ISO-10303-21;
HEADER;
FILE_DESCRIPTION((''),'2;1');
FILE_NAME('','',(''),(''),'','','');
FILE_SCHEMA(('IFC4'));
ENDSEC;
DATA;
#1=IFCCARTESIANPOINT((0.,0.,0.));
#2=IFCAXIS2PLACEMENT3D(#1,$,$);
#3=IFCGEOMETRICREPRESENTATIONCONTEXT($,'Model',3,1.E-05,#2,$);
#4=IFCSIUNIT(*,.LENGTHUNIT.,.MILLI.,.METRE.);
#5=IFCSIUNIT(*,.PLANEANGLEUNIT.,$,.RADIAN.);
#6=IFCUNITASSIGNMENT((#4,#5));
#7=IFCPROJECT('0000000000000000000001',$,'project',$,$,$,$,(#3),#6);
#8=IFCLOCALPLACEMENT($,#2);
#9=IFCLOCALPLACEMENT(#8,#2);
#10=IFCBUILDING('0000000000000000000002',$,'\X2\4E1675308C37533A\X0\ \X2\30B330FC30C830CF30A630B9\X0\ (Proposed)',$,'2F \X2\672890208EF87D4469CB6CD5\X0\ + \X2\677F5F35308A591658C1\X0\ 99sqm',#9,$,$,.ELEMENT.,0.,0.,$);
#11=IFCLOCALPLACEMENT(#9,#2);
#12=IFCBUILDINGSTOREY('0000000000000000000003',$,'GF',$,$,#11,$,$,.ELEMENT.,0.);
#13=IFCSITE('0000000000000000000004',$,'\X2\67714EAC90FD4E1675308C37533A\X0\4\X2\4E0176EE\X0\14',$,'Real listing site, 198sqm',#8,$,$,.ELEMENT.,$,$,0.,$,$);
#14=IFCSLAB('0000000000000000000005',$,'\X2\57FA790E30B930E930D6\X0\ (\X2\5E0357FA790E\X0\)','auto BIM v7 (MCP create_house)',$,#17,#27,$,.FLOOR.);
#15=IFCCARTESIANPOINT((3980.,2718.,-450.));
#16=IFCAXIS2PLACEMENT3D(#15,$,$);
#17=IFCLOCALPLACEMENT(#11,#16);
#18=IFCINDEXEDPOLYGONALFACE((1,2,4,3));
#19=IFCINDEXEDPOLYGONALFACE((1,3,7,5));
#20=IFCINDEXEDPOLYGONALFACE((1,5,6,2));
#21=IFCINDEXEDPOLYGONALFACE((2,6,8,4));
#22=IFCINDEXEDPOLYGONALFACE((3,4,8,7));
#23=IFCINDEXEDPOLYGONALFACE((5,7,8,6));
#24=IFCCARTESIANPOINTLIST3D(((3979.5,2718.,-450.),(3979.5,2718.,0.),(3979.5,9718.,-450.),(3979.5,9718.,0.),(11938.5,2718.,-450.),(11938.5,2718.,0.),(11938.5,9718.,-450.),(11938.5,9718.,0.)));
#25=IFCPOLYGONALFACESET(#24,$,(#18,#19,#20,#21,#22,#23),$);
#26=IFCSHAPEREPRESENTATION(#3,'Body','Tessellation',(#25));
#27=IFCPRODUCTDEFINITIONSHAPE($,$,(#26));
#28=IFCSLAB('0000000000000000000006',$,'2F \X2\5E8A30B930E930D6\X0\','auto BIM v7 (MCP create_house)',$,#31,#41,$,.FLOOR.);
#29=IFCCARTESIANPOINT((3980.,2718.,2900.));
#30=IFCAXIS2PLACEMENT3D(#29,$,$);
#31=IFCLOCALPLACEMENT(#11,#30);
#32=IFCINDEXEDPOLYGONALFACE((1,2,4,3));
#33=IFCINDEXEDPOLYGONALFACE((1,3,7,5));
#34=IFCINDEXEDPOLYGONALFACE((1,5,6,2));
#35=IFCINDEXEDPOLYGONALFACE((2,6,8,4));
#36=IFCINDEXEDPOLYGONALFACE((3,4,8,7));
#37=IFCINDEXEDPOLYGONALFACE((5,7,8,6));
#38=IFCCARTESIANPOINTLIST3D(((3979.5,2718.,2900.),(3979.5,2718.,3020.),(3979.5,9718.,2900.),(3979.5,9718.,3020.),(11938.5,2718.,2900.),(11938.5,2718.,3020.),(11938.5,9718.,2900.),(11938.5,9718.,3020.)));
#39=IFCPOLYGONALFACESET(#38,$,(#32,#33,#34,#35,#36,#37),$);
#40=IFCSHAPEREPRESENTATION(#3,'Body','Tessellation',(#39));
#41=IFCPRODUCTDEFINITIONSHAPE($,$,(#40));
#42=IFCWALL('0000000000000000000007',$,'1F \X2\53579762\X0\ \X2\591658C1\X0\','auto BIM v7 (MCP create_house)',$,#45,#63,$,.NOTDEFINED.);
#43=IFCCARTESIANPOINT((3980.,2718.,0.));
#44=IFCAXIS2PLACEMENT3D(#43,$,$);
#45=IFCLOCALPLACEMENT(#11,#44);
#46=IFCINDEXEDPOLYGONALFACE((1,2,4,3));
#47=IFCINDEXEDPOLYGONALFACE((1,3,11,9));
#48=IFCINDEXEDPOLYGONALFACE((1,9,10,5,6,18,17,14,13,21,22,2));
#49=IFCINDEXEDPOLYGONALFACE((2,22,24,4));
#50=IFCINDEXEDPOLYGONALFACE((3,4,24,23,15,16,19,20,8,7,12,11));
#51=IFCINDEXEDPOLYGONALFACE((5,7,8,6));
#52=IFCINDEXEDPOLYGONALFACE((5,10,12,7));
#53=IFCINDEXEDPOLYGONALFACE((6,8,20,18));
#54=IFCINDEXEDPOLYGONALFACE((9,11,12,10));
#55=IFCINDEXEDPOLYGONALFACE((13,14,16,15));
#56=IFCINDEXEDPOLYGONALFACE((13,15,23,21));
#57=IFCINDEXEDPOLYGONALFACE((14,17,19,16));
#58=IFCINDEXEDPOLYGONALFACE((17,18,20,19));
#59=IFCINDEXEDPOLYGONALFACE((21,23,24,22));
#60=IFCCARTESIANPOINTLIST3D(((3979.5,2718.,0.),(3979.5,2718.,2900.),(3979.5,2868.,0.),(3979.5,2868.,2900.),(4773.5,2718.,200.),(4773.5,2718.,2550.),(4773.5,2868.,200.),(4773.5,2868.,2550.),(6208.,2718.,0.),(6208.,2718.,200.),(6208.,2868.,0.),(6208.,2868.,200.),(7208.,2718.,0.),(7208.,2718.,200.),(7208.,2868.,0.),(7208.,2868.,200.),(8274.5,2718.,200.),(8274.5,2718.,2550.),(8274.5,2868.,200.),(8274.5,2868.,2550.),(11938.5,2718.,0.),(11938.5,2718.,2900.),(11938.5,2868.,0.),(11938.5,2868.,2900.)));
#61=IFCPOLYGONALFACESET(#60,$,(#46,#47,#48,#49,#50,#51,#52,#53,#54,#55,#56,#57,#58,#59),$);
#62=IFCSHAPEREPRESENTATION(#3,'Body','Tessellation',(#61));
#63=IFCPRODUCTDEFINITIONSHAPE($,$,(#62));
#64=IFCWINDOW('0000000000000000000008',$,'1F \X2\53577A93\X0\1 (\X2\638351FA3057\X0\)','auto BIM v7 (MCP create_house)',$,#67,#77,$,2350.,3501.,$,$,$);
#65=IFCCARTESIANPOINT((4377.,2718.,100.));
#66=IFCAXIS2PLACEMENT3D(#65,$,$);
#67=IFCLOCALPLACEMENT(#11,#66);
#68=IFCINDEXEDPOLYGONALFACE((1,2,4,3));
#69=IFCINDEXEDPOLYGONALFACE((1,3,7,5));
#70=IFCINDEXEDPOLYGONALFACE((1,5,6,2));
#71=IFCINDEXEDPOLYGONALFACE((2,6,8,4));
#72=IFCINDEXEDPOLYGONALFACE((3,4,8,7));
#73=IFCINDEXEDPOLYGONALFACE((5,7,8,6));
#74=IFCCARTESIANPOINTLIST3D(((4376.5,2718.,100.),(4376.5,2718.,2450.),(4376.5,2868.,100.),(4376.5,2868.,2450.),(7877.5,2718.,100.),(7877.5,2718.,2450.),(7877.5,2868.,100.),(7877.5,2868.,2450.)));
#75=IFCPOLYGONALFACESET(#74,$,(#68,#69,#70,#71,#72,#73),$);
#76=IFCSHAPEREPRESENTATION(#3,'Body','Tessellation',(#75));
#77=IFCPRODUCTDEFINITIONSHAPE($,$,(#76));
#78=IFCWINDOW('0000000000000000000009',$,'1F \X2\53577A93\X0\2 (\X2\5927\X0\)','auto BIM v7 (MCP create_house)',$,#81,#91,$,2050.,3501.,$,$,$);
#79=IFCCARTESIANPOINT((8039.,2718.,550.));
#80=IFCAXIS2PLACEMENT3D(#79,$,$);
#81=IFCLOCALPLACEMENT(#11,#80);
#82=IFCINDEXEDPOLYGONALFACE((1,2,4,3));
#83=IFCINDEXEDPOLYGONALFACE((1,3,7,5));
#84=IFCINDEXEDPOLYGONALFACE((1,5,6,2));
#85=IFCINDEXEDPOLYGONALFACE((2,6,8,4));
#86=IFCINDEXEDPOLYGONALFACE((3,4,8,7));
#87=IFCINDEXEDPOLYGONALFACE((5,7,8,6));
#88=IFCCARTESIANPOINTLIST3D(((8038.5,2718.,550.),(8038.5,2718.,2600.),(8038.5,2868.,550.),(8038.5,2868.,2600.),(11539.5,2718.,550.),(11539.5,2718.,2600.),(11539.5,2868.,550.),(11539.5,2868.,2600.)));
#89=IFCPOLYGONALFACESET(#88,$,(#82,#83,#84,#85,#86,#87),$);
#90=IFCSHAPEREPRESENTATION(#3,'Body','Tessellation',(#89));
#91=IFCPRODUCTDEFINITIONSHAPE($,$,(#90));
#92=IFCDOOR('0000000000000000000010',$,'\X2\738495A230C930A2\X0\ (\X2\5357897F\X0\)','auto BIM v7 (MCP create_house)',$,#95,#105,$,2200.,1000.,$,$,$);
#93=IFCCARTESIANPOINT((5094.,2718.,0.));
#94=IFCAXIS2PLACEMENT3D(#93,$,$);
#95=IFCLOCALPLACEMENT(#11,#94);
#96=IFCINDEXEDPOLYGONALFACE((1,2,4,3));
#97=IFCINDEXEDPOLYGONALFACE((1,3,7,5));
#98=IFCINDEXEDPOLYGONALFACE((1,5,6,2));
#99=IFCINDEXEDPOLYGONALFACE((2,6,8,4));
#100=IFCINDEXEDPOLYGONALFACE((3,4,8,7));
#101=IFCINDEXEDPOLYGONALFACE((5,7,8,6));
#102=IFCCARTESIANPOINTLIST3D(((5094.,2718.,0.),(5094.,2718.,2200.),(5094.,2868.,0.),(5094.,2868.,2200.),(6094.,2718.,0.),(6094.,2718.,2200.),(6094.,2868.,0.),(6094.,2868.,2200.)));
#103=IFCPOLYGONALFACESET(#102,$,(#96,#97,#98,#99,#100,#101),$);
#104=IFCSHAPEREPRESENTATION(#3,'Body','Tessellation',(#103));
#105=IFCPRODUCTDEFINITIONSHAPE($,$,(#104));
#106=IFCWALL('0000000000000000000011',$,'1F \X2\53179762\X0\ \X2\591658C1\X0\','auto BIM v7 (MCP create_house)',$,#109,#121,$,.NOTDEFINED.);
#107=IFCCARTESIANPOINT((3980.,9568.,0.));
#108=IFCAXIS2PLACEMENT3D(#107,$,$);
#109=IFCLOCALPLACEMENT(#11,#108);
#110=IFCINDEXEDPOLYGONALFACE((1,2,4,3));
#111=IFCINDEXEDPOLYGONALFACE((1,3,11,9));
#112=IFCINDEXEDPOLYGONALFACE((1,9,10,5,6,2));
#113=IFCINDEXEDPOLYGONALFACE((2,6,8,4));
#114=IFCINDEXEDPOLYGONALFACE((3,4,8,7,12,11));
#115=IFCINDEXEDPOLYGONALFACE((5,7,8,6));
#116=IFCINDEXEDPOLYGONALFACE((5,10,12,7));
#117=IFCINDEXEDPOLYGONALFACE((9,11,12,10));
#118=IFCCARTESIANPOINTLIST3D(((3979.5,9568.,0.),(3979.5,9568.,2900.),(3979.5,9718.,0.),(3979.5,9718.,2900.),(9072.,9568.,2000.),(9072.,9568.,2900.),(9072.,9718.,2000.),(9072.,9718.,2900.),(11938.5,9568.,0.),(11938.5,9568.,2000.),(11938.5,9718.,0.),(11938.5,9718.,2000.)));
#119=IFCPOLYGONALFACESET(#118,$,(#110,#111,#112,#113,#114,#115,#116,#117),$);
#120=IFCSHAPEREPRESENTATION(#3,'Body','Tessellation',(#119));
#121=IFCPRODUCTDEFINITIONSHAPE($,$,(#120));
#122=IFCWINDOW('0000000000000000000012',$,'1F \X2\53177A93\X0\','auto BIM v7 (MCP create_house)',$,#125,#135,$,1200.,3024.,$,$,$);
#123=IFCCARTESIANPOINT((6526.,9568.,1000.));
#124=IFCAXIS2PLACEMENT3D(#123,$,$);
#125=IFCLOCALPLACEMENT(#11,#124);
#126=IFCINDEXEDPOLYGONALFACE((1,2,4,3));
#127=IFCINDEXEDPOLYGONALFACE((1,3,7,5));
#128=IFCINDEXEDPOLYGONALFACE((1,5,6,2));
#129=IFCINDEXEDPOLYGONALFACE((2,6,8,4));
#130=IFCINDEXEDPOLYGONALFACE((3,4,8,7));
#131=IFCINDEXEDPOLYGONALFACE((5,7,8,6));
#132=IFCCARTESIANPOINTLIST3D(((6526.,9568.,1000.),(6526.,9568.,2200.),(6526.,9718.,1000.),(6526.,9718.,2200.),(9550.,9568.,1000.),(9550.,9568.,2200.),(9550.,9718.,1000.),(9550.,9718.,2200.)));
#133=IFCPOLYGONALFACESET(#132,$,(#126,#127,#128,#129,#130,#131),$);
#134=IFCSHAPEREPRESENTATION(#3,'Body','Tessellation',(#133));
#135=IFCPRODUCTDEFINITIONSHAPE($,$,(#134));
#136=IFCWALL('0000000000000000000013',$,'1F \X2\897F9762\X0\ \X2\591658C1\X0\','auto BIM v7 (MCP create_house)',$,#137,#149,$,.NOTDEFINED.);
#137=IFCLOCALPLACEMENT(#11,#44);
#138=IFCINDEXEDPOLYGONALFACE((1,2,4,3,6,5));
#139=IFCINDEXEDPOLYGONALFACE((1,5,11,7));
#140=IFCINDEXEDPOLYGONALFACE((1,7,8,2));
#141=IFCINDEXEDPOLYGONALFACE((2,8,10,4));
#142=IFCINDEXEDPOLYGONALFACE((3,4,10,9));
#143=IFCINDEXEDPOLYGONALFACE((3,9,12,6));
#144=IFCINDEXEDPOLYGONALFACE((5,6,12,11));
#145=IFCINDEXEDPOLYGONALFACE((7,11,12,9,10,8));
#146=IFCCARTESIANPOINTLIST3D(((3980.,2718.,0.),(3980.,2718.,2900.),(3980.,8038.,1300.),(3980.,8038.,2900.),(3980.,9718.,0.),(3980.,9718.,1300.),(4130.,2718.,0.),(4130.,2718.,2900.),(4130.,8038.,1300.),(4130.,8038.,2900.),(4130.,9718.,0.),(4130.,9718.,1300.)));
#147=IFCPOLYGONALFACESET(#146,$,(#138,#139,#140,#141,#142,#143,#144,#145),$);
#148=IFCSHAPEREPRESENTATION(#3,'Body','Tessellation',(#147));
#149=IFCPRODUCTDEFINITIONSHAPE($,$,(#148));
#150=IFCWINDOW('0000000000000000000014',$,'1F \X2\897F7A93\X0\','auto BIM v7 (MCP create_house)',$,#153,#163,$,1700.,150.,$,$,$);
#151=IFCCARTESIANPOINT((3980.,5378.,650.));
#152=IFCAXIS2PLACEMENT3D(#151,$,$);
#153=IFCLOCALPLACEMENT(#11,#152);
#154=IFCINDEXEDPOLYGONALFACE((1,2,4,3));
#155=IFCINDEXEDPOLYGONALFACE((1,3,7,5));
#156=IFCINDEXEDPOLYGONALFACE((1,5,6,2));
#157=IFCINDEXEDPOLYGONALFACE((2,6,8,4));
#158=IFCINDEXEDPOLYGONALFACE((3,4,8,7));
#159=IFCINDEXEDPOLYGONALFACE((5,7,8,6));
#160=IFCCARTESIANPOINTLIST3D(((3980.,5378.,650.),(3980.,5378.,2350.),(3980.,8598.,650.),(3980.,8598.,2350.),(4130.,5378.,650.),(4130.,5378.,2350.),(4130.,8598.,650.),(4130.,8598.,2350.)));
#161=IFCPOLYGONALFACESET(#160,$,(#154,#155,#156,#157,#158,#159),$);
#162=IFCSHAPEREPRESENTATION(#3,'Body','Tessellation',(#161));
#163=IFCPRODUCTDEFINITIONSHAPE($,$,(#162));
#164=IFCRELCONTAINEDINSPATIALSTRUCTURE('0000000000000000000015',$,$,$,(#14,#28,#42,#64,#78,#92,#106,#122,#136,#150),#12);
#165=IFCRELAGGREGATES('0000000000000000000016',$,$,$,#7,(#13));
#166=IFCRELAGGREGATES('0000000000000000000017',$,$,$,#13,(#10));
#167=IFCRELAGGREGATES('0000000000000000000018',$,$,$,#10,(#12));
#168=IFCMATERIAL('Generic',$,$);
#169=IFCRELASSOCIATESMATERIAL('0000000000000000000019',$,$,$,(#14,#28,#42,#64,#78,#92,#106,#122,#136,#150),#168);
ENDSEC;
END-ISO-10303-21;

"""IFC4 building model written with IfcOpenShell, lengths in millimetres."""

from ifc_helpers import new_model, si_unit, frame, frame_2d, origin, place, context, project, spatial, rectangle, extrude, material, element, fill, save


model = new_model("IFC4")

# Units and contexts
model_context = context("Model", 3, precision=1e-05, world=origin())
ifc_project = project(units=[si_unit("LENGTHUNIT", "METRE", prefix="MILLI"), si_unit("PLANEANGLEUNIT", "RADIAN")], contexts=[model_context])

# Site, building, storey
site_placement = place(None, origin())
site = spatial("IfcSite", under=ifc_project, at=site_placement, Name="東京都世田谷区4丁目14", ObjectType="Real listing site, 198sqm", CompositionType="ELEMENT", RefElevation=0.0)
building_placement = place(site_placement, origin())
building = spatial("IfcBuilding", under=site, at=building_placement, Name="世田谷区 コートハウス (Proposed)", ObjectType="2F 木造軸組構法 + 板張り外壁 99sqm", CompositionType="ELEMENT", ElevationOfRefHeight=0.0, ElevationOfTerrain=0.0)
storey_placement = place(building_placement, origin())
storey = spatial("IfcBuildingStorey", under=building, at=storey_placement, Name="GF", CompositionType="ELEMENT", Elevation=0.0)

# Slabs
ifc_material = material(Name="Generic")
slab_1_placement = place(storey_placement, frame((3980.0, 2718.0, -450.0)))
element("IfcSlab", 1, at=slab_1_placement, inside=storey, material=ifc_material, Name="基礎スラブ (布基礎)", Description="auto BIM v7 (MCP create_house)", PredefinedType="FLOOR", context=model_context, shape_type="SweptSolid", body=[
    extrude(rectangle(XDim=7959.0, YDim=7000.0, at=frame_2d((3979.0, 3500.0))), frame((3980.0, 2718.0, -450.0)), (0.0, 0.0, 1.0), 450.0),
])
slab_2_placement = place(storey_placement, frame((3980.0, 2718.0, 2900.0)))
element("IfcSlab", 2, at=slab_2_placement, inside=storey, material=ifc_material, Name="2F 床スラブ", Description="auto BIM v7 (MCP create_house)", PredefinedType="FLOOR", context=model_context, shape_type="SweptSolid", body=[
    extrude(rectangle(XDim=7959.0, YDim=7000.0, at=frame_2d((3979.0, 3500.0))), frame((3980.0, 2718.0, 2900.0)), (0.0, 0.0, 1.0), 120.0),
])

# Wall, openings, windows, door
wall_1_placement = place(storey_placement, frame((3980.0, 2718.0, 0.0)))
wall_1 = element("IfcWall", 3, at=wall_1_placement, inside=storey, material=ifc_material, Name="1F 南面 外壁", Description="auto BIM v7 (MCP create_house)", PredefinedType="NOTDEFINED", context=model_context, shape_type="SweptSolid", body=[
    extrude(rectangle(XDim=7959.0, YDim=150.0, at=frame_2d((3979.0, 75.0))), frame((3980.0, 2718.0, 0.0)), (0.0, 0.0, 1.0), 2900.0),
])
opening_1_placement = place(storey_placement, frame((4377.0, 2718.0, 100.0)))
opening_1 = element("IfcOpeningElement", 4, at=opening_1_placement, cuts=wall_1, PredefinedType="NOTDEFINED", context=model_context, shape_type="SweptSolid", body=[
    extrude(rectangle(XDim=3501.0, YDim=150.0, at=frame_2d((1750.0, 75.0))), frame((4377.0, 2718.0, 100.0)), (0.0, 0.0, 1.0), 2350.0),
])
opening_2_placement = place(storey_placement, frame((8039.0, 2718.0, 550.0)))
opening_2 = element("IfcOpeningElement", 5, at=opening_2_placement, cuts=wall_1, PredefinedType="NOTDEFINED", context=model_context, shape_type="SweptSolid", body=[
    extrude(rectangle(XDim=3501.0, YDim=150.0, at=frame_2d((1750.0, 75.0))), frame((8039.0, 2718.0, 550.0)), (0.0, 0.0, 1.0), 2050.0),
])
opening_3_placement = place(storey_placement, frame((5094.0, 2718.0, 0.0)))
opening_3 = element("IfcOpeningElement", 6, at=opening_3_placement, cuts=wall_1, PredefinedType="NOTDEFINED", context=model_context, shape_type="SweptSolid", body=[
    extrude(rectangle(XDim=1000.0, YDim=150.0, at=frame_2d((500.0, 75.0))), frame((5094.0, 2718.0, 0.0)), (0.0, 0.0, 1.0), 2200.0),
])
window_1_placement = place(storey_placement, frame((4377.0, 2718.0, 100.0)))
window_1 = element("IfcWindow", 7, at=window_1_placement, inside=storey, material=ifc_material, Name="1F 南窓1 (掃出し)", Description="auto BIM v7 (MCP create_house)", OverallHeight=2350.0, OverallWidth=3501.0, context=model_context, shape_type="SweptSolid", body=[
    extrude(rectangle(XDim=3501.0, YDim=150.0, at=frame_2d((1750.0, 75.0))), frame((4377.0, 2718.0, 100.0)), (0.0, 0.0, 1.0), 2350.0),
])
fill(opening_1, window_1)
window_2_placement = place(storey_placement, frame((8039.0, 2718.0, 550.0)))
window_2 = element("IfcWindow", 8, at=window_2_placement, inside=storey, material=ifc_material, Name="1F 南窓2 (大)", Description="auto BIM v7 (MCP create_house)", OverallHeight=2050.0, OverallWidth=3501.0, context=model_context, shape_type="SweptSolid", body=[
    extrude(rectangle(XDim=3501.0, YDim=150.0, at=frame_2d((1750.0, 75.0))), frame((8039.0, 2718.0, 550.0)), (0.0, 0.0, 1.0), 2050.0),
])
fill(opening_2, window_2)
door_placement = place(storey_placement, frame((5094.0, 2718.0, 0.0)))
door = element("IfcDoor", 9, at=door_placement, inside=storey, material=ifc_material, Name="玄関ドア (南西)", Description="auto BIM v7 (MCP create_house)", OverallHeight=2200.0, OverallWidth=1000.0, context=model_context, shape_type="SweptSolid", body=[
    extrude(rectangle(XDim=1000.0, YDim=150.0, at=frame_2d((500.0, 75.0))), frame((5094.0, 2718.0, 0.0)), (0.0, 0.0, 1.0), 2200.0),
])
fill(opening_3, door)

# Walls, openings, windows
wall_2_placement = place(storey_placement, frame((3980.0, 9568.0, 0.0)))
wall_2 = element("IfcWall", 10, at=wall_2_placement, inside=storey, material=ifc_material, Name="1F 北面 外壁", Description="auto BIM v7 (MCP create_house)", PredefinedType="NOTDEFINED", context=model_context, shape_type="SweptSolid", body=[
    extrude(rectangle(XDim=7959.0, YDim=150.0, at=frame_2d((3979.0, 75.0))), frame((3980.0, 9568.0, 0.0)), (0.0, 0.0, 1.0), 2900.0),
])
opening_4_placement = place(storey_placement, frame((6526.0, 9568.0, 1000.0)))
opening_4 = element("IfcOpeningElement", 11, at=opening_4_placement, cuts=wall_2, PredefinedType="NOTDEFINED", context=model_context, shape_type="SweptSolid", body=[
    extrude(rectangle(XDim=3024.0, YDim=150.0, at=frame_2d((1512.0, 75.0))), frame((6526.0, 9568.0, 1000.0)), (0.0, 0.0, 1.0), 1200.0),
])
window_3_placement = place(storey_placement, frame((6526.0, 9568.0, 1000.0)))
window_3 = element("IfcWindow", 12, at=window_3_placement, inside=storey, material=ifc_material, Name="1F 北窓", Description="auto BIM v7 (MCP create_house)", OverallHeight=1200.0, OverallWidth=3024.0, context=model_context, shape_type="SweptSolid", body=[
    extrude(rectangle(XDim=3024.0, YDim=150.0, at=frame_2d((1512.0, 75.0))), frame((6526.0, 9568.0, 1000.0)), (0.0, 0.0, 1.0), 1200.0),
])
fill(opening_4, window_3)
wall_3_placement = place(storey_placement, frame((3980.0, 2718.0, 0.0)))
wall_3 = element("IfcWall", 13, at=wall_3_placement, inside=storey, material=ifc_material, Name="1F 西面 外壁", Description="auto BIM v7 (MCP create_house)", PredefinedType="NOTDEFINED", context=model_context, shape_type="SweptSolid", body=[
    extrude(rectangle(XDim=150.0, YDim=7000.0, at=frame_2d((75.0, 3500.0))), frame((3980.0, 2718.0, 0.0)), (0.0, 0.0, 1.0), 2900.0),
])
opening_5_placement = place(storey_placement, frame((3980.0, 5378.0, 650.0)))
opening_5 = element("IfcOpeningElement", 14, at=opening_5_placement, cuts=wall_3, PredefinedType="NOTDEFINED", context=model_context, shape_type="SweptSolid", body=[
    extrude(rectangle(XDim=150.0, YDim=3220.0, at=frame_2d((75.0, 1610.0))), frame((3980.0, 5378.0, 650.0)), (0.0, 0.0, 1.0), 1700.0),
])
window_4_placement = place(storey_placement, frame((3980.0, 5378.0, 650.0)))
window_4 = element("IfcWindow", 15, at=window_4_placement, inside=storey, material=ifc_material, Name="1F 西窓", Description="auto BIM v7 (MCP create_house)", OverallHeight=1700.0, OverallWidth=150.0, context=model_context, shape_type="SweptSolid", body=[
    extrude(rectangle(XDim=150.0, YDim=3220.0, at=frame_2d((75.0, 1610.0))), frame((3980.0, 5378.0, 650.0)), (0.0, 0.0, 1.0), 1700.0),
])
fill(opening_5, window_4)

save(model, "model.ifc")
